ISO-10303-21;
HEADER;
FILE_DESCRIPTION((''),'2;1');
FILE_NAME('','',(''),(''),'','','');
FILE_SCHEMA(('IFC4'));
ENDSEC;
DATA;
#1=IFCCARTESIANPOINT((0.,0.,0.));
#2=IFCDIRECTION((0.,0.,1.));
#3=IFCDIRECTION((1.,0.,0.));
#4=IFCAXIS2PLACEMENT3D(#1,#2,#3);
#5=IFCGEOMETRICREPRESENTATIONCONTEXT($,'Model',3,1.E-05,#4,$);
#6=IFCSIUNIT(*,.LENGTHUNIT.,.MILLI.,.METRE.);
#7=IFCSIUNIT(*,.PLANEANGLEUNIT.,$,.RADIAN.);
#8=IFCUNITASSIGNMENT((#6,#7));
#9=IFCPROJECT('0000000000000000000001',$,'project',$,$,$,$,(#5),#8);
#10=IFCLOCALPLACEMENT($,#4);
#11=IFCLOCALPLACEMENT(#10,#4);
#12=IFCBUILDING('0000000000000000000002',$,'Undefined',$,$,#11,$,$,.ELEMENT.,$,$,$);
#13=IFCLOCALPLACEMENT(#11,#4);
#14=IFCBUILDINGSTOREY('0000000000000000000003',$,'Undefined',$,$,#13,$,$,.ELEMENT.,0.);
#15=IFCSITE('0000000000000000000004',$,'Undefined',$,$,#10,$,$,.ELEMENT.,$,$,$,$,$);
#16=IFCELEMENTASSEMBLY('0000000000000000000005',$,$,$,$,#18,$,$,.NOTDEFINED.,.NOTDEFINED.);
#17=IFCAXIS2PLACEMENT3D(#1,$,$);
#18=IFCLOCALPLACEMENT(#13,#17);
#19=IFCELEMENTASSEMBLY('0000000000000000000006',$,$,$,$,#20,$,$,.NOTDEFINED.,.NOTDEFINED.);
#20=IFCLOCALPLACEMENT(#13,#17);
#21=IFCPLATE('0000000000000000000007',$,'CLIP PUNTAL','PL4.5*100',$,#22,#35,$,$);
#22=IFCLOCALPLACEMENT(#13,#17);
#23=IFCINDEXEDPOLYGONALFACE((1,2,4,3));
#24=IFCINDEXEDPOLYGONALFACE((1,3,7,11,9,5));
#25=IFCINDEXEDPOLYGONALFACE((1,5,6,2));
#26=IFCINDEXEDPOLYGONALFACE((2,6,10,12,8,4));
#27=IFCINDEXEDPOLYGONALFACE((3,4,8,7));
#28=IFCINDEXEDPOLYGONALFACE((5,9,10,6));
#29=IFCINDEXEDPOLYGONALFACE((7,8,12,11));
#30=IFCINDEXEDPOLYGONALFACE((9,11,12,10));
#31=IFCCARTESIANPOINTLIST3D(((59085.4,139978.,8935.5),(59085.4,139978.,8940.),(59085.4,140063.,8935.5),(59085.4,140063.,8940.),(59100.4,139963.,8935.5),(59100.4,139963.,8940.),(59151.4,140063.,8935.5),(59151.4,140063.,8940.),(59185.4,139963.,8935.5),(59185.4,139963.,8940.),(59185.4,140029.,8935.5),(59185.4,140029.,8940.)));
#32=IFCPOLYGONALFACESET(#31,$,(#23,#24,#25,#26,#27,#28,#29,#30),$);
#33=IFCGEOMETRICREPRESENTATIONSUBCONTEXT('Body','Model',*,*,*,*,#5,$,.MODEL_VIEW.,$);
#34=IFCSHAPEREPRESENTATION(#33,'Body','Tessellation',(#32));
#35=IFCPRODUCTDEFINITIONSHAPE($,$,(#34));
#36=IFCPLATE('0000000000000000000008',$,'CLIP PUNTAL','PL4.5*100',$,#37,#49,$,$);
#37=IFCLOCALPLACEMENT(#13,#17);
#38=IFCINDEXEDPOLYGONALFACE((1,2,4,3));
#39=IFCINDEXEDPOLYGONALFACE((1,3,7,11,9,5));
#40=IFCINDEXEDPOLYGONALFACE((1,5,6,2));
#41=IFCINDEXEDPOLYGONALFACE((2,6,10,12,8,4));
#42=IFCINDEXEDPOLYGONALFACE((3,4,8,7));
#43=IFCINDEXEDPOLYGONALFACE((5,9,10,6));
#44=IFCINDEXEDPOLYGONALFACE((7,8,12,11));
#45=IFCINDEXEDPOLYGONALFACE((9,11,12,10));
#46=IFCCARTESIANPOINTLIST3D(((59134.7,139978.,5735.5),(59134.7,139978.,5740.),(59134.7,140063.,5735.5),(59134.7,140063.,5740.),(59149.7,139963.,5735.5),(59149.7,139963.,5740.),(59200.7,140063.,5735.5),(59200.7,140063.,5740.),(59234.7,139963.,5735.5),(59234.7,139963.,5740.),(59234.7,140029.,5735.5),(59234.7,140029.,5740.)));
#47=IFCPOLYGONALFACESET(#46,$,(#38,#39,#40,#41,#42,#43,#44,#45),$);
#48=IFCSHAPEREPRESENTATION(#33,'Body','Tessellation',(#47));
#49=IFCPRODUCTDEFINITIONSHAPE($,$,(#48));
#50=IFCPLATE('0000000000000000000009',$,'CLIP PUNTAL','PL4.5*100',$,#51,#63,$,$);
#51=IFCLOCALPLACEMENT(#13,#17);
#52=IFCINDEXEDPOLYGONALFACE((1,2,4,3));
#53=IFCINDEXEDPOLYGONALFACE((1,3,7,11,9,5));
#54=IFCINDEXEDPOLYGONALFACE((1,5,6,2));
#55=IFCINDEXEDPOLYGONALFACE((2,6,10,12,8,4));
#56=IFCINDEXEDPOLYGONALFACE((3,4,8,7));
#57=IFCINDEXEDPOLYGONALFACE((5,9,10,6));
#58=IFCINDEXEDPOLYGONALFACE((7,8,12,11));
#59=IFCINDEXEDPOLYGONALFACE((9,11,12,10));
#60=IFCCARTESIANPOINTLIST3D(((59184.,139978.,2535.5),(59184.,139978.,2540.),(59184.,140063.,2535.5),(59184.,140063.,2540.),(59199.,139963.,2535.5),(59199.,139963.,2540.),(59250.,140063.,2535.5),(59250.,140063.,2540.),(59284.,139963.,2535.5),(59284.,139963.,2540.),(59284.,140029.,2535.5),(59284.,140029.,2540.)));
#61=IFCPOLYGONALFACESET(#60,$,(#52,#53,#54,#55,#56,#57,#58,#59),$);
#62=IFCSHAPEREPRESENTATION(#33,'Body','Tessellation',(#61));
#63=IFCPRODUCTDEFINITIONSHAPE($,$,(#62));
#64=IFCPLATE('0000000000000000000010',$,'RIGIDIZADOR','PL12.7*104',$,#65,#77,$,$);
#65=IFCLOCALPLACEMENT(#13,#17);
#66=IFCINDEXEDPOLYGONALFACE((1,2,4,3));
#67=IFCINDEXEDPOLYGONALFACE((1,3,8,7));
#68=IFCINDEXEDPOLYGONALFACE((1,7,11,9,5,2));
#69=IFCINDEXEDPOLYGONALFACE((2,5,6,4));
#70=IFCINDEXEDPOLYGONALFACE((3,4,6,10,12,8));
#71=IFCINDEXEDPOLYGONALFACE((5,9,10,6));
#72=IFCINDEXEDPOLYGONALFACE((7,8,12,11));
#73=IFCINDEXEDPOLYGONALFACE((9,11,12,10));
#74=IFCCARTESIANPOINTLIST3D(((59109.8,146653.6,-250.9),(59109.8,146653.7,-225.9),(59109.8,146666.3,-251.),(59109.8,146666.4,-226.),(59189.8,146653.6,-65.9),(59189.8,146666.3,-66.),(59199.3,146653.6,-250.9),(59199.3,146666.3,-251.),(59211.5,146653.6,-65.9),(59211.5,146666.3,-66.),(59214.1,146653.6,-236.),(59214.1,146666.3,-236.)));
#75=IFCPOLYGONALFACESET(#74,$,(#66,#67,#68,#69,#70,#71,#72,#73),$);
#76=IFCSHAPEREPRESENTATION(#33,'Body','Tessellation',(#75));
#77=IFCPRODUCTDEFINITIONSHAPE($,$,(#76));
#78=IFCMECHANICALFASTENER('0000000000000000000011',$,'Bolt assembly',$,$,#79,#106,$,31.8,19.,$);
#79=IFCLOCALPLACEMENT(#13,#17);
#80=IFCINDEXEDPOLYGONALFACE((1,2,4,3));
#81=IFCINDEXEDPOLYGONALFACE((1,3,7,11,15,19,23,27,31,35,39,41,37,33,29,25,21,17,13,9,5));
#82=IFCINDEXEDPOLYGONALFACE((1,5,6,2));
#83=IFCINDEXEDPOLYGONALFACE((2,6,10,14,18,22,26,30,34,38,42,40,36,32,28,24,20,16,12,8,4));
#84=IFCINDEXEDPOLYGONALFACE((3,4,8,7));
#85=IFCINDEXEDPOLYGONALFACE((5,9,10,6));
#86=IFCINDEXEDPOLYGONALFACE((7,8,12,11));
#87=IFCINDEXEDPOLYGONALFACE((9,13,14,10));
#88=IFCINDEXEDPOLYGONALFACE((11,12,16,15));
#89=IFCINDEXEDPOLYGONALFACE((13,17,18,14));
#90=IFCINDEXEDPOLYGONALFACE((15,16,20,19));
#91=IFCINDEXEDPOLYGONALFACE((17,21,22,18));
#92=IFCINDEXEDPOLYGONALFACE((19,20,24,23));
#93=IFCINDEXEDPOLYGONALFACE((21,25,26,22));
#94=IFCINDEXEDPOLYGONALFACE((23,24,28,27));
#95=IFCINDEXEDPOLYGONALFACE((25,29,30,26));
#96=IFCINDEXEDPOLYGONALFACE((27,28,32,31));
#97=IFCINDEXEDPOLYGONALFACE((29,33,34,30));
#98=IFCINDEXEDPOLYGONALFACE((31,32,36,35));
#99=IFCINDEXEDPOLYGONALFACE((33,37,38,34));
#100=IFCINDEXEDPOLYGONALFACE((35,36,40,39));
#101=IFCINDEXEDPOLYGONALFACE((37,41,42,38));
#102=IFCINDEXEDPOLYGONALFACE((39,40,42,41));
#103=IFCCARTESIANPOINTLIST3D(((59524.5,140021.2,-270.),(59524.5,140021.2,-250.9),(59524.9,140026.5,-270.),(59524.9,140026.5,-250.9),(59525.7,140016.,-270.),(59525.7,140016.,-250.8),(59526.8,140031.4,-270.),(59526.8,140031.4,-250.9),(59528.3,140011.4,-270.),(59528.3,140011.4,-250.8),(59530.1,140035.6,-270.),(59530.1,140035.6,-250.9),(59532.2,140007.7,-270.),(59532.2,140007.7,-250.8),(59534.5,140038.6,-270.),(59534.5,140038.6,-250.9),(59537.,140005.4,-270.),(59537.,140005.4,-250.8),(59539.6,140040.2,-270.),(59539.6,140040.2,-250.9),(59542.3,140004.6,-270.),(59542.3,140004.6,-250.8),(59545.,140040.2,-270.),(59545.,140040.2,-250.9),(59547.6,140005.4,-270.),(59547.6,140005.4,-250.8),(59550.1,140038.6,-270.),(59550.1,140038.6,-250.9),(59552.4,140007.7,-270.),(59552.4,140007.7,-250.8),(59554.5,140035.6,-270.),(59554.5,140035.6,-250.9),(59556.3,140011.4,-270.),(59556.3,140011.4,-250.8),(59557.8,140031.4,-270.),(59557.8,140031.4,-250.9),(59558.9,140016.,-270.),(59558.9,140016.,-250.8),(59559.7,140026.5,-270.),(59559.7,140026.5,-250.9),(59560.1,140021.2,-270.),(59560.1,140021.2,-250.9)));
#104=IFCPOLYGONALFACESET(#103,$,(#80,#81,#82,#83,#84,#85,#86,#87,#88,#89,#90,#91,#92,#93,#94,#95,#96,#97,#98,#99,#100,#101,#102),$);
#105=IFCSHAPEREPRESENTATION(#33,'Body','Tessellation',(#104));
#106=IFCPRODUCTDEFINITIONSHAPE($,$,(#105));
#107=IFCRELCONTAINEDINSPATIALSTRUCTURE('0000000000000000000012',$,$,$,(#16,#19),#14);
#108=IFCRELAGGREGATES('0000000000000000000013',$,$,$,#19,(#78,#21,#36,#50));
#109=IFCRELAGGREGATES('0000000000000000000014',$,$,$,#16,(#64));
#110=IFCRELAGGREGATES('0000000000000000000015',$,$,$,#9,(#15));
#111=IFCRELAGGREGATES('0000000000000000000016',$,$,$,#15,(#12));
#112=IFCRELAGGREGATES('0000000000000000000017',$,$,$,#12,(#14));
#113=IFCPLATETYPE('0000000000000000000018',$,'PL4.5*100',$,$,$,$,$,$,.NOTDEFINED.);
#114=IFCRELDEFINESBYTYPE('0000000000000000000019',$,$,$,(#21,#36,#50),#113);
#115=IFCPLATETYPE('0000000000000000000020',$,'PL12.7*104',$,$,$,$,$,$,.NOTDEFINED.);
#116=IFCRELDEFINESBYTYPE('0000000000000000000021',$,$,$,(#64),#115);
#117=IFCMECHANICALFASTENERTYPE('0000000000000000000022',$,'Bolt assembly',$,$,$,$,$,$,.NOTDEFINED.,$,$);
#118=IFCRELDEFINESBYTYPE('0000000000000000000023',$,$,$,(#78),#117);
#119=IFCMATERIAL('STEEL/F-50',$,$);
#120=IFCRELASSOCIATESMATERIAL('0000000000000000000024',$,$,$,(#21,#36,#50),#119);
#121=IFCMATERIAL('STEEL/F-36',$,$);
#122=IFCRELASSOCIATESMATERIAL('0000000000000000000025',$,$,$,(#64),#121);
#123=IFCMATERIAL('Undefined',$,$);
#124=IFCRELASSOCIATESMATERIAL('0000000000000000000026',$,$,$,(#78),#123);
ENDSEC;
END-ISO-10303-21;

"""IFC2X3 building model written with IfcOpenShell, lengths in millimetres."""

from ifc_helpers import new_model, si_unit, frame, origin_with_axes, origin_2d_with_axis, place, context, subcontext, project, spatial, polyline, circle, outline, extrude, source, transform, mapped, material, type_object, element, aggregate, save


model = new_model("IFC2X3")

# Units and contexts
model_context = context("Model", 3, precision=1e-05, world=origin_with_axes())
body_context = subcontext(model_context, "Body", "Model", "MODEL_VIEW")
ifc_project = project(units=[si_unit("LENGTHUNIT", "METRE", prefix="MILLI"), si_unit("PLANEANGLEUNIT", "RADIAN")], contexts=[model_context])

# Site, building, storey
site_placement = place(None, origin_with_axes())
site = spatial("IfcSite", under=ifc_project, at=site_placement, Name="Undefined", CompositionType="ELEMENT")
building_placement = place(site_placement, origin_with_axes())
building = spatial("IfcBuilding", under=site, at=building_placement, Name="Undefined", CompositionType="ELEMENT")
storey_placement = place(building_placement, origin_with_axes())
storey = spatial("IfcBuildingStorey", under=building, at=storey_placement, Name="Undefined", CompositionType="ELEMENT", Elevation=0.0)

# Element assembly
assembly_1_placement = place(storey_placement, origin_with_axes())
assembly_1 = element("IfcElementAssembly", 1, at=assembly_1_placement, inside=storey, AssemblyPlace="NOTDEFINED", PredefinedType="NOTDEFINED")
ifc_material_1 = material(Name="STEEL/F-36")

# Shared definitions
ifc_material_2 = material(Name="STEEL/F-50")

# Shared definitions
plate_type_1 = type_object("IfcPlateType", Name="PL4.5*100", PredefinedType="NOTDEFINED")

# Element assembly, plates
assembly_2_placement = place(storey_placement, origin_with_axes())
assembly_2 = element("IfcElementAssembly", 2, at=assembly_2_placement, inside=storey, AssemblyPlace="NOTDEFINED", PredefinedType="NOTDEFINED")
plate_1_placement = place(assembly_2_placement, frame((59185.4, 139963.0, 8937.7), z_axis=(0.0, 0.0, 1.0), x_axis=(0.0, 1.0, 0.0)))
plate_1 = element("IfcPlate", 3, at=plate_1_placement, type_object=plate_type_1, material=ifc_material_2, Name="CLIP PUNTAL", Description="PL4.5*100", context=body_context, shape_type="SweptSolid", body=[
    extrude(outline(polyline([(0.0, 0.0), (66.0, 0.0), (100.0, 34.0), (100.0, 100.0), (15.0, 100.0), (0.0, 85.0), (0.0, 0.0)])), frame((0.0, 0.0, -2.2), z_axis=(0.0, 0.0, 1.0), x_axis=(1.0, 0.0, 0.0)), (0.0, 0.0, 1.0), 4.5),
])
plate_2_placement = place(assembly_2_placement, frame((59234.7, 139963.0, 5737.8), z_axis=(0.0, 0.0, 1.0), x_axis=(0.0, 1.0, 0.0)))
plate_2 = element("IfcPlate", 4, at=plate_2_placement, type_object=plate_type_1, material=ifc_material_2, Name="CLIP PUNTAL", Description="PL4.5*100", context=body_context, shape_type="SweptSolid", body=[
    extrude(outline(polyline([(0.0, 0.0), (66.0, 0.0), (100.0, 34.0), (100.0, 100.0), (15.0, 100.0), (0.0, 85.0), (0.0, 0.0)])), frame((0.0, 0.0, -2.2), z_axis=(0.0, 0.0, 1.0), x_axis=(1.0, 0.0, 0.0)), (0.0, 0.0, 1.0), 4.5),
])
plate_3_placement = place(assembly_2_placement, frame((59284.0, 139963.0, 2537.7), z_axis=(0.0, 0.0, 1.0), x_axis=(0.0, 1.0, 0.0)))
plate_3 = element("IfcPlate", 5, at=plate_3_placement, type_object=plate_type_1, material=ifc_material_2, Name="CLIP PUNTAL", Description="PL4.5*100", context=body_context, shape_type="SweptSolid", body=[
    extrude(outline(polyline([(0.0, 0.0), (66.0, 0.0), (100.0, 34.0), (100.0, 100.0), (15.0, 100.0), (0.0, 85.0), (0.0, 0.0)])), frame((0.0, 0.0, -2.2), z_axis=(0.0, 0.0, 1.0), x_axis=(1.0, 0.0, 0.0)), (0.0, 0.0, 1.0), 4.5),
])

# Plate
plate_type_2 = type_object("IfcPlateType", Name="PL12.7*104", PredefinedType="NOTDEFINED")
plate_4_placement = place(assembly_1_placement, frame((59109.8, 146660.0, -250.9), z_axis=(0.0, -1.0, 0.0), x_axis=(1.0, 0.0, 0.0)))
plate_4 = element("IfcPlate", 6, at=plate_4_placement, type_object=plate_type_2, material=ifc_material_1, Name="RIGIDIZADOR", Description="PL12.7*104", context=body_context, shape_type="SweptSolid", body=[
    extrude(outline(polyline([(0.0, 0.0), (89.5, 0.0), (104.3, 15.0), (101.7, 185.0), (80.0, 185.0), (0.0, 25.0), (0.0, 0.0)])), frame((0.0, 0.0, -6.4), z_axis=(0.0, 0.0, 1.0), x_axis=(1.0, 0.0, 0.0)), (0.0, 0.0, 1.0), 12.7),
])

# Mechanical fastener
ifc_material_3 = material(Name="Undefined")
mechanical_fastener_type = type_object("IfcMechanicalFastenerType", Name="Bolt assembly")
shared_shape_1 = source(origin_with_axes(), body_context, "Body", "SweptSolid", [
    extrude(circle(Radius=17.9, at=origin_2d_with_axis()), frame((0.0, -19.1, 0.0), z_axis=(0.0, 1.0, 0.0), x_axis=(1.0, 0.0, 0.0)), (0.0, 0.0, 1.0), 19.1),
])
mechanical_fastener_1_placement = place(assembly_2_placement, frame((59542.3, 140022.5, -250.9), z_axis=(-1.0, 0.0, 0.0), x_axis=(0.0, -1.0, 0.0)))
mechanical_fastener_1 = element("IfcMechanicalFastener", 7, at=mechanical_fastener_1_placement, type_object=mechanical_fastener_type, material=ifc_material_3, Name="Bolt assembly", NominalDiameter=31.8, NominalLength=19.0, context=body_context, shape_type="MappedRepresentation", body=[
    mapped(shared_shape_1, transform((0.0, 0.0, 0.0))),
])
aggregate(assembly_2, [mechanical_fastener_1, plate_1, plate_2, plate_3])
aggregate(assembly_1, [plate_4])

save(model, "model.ifc")
